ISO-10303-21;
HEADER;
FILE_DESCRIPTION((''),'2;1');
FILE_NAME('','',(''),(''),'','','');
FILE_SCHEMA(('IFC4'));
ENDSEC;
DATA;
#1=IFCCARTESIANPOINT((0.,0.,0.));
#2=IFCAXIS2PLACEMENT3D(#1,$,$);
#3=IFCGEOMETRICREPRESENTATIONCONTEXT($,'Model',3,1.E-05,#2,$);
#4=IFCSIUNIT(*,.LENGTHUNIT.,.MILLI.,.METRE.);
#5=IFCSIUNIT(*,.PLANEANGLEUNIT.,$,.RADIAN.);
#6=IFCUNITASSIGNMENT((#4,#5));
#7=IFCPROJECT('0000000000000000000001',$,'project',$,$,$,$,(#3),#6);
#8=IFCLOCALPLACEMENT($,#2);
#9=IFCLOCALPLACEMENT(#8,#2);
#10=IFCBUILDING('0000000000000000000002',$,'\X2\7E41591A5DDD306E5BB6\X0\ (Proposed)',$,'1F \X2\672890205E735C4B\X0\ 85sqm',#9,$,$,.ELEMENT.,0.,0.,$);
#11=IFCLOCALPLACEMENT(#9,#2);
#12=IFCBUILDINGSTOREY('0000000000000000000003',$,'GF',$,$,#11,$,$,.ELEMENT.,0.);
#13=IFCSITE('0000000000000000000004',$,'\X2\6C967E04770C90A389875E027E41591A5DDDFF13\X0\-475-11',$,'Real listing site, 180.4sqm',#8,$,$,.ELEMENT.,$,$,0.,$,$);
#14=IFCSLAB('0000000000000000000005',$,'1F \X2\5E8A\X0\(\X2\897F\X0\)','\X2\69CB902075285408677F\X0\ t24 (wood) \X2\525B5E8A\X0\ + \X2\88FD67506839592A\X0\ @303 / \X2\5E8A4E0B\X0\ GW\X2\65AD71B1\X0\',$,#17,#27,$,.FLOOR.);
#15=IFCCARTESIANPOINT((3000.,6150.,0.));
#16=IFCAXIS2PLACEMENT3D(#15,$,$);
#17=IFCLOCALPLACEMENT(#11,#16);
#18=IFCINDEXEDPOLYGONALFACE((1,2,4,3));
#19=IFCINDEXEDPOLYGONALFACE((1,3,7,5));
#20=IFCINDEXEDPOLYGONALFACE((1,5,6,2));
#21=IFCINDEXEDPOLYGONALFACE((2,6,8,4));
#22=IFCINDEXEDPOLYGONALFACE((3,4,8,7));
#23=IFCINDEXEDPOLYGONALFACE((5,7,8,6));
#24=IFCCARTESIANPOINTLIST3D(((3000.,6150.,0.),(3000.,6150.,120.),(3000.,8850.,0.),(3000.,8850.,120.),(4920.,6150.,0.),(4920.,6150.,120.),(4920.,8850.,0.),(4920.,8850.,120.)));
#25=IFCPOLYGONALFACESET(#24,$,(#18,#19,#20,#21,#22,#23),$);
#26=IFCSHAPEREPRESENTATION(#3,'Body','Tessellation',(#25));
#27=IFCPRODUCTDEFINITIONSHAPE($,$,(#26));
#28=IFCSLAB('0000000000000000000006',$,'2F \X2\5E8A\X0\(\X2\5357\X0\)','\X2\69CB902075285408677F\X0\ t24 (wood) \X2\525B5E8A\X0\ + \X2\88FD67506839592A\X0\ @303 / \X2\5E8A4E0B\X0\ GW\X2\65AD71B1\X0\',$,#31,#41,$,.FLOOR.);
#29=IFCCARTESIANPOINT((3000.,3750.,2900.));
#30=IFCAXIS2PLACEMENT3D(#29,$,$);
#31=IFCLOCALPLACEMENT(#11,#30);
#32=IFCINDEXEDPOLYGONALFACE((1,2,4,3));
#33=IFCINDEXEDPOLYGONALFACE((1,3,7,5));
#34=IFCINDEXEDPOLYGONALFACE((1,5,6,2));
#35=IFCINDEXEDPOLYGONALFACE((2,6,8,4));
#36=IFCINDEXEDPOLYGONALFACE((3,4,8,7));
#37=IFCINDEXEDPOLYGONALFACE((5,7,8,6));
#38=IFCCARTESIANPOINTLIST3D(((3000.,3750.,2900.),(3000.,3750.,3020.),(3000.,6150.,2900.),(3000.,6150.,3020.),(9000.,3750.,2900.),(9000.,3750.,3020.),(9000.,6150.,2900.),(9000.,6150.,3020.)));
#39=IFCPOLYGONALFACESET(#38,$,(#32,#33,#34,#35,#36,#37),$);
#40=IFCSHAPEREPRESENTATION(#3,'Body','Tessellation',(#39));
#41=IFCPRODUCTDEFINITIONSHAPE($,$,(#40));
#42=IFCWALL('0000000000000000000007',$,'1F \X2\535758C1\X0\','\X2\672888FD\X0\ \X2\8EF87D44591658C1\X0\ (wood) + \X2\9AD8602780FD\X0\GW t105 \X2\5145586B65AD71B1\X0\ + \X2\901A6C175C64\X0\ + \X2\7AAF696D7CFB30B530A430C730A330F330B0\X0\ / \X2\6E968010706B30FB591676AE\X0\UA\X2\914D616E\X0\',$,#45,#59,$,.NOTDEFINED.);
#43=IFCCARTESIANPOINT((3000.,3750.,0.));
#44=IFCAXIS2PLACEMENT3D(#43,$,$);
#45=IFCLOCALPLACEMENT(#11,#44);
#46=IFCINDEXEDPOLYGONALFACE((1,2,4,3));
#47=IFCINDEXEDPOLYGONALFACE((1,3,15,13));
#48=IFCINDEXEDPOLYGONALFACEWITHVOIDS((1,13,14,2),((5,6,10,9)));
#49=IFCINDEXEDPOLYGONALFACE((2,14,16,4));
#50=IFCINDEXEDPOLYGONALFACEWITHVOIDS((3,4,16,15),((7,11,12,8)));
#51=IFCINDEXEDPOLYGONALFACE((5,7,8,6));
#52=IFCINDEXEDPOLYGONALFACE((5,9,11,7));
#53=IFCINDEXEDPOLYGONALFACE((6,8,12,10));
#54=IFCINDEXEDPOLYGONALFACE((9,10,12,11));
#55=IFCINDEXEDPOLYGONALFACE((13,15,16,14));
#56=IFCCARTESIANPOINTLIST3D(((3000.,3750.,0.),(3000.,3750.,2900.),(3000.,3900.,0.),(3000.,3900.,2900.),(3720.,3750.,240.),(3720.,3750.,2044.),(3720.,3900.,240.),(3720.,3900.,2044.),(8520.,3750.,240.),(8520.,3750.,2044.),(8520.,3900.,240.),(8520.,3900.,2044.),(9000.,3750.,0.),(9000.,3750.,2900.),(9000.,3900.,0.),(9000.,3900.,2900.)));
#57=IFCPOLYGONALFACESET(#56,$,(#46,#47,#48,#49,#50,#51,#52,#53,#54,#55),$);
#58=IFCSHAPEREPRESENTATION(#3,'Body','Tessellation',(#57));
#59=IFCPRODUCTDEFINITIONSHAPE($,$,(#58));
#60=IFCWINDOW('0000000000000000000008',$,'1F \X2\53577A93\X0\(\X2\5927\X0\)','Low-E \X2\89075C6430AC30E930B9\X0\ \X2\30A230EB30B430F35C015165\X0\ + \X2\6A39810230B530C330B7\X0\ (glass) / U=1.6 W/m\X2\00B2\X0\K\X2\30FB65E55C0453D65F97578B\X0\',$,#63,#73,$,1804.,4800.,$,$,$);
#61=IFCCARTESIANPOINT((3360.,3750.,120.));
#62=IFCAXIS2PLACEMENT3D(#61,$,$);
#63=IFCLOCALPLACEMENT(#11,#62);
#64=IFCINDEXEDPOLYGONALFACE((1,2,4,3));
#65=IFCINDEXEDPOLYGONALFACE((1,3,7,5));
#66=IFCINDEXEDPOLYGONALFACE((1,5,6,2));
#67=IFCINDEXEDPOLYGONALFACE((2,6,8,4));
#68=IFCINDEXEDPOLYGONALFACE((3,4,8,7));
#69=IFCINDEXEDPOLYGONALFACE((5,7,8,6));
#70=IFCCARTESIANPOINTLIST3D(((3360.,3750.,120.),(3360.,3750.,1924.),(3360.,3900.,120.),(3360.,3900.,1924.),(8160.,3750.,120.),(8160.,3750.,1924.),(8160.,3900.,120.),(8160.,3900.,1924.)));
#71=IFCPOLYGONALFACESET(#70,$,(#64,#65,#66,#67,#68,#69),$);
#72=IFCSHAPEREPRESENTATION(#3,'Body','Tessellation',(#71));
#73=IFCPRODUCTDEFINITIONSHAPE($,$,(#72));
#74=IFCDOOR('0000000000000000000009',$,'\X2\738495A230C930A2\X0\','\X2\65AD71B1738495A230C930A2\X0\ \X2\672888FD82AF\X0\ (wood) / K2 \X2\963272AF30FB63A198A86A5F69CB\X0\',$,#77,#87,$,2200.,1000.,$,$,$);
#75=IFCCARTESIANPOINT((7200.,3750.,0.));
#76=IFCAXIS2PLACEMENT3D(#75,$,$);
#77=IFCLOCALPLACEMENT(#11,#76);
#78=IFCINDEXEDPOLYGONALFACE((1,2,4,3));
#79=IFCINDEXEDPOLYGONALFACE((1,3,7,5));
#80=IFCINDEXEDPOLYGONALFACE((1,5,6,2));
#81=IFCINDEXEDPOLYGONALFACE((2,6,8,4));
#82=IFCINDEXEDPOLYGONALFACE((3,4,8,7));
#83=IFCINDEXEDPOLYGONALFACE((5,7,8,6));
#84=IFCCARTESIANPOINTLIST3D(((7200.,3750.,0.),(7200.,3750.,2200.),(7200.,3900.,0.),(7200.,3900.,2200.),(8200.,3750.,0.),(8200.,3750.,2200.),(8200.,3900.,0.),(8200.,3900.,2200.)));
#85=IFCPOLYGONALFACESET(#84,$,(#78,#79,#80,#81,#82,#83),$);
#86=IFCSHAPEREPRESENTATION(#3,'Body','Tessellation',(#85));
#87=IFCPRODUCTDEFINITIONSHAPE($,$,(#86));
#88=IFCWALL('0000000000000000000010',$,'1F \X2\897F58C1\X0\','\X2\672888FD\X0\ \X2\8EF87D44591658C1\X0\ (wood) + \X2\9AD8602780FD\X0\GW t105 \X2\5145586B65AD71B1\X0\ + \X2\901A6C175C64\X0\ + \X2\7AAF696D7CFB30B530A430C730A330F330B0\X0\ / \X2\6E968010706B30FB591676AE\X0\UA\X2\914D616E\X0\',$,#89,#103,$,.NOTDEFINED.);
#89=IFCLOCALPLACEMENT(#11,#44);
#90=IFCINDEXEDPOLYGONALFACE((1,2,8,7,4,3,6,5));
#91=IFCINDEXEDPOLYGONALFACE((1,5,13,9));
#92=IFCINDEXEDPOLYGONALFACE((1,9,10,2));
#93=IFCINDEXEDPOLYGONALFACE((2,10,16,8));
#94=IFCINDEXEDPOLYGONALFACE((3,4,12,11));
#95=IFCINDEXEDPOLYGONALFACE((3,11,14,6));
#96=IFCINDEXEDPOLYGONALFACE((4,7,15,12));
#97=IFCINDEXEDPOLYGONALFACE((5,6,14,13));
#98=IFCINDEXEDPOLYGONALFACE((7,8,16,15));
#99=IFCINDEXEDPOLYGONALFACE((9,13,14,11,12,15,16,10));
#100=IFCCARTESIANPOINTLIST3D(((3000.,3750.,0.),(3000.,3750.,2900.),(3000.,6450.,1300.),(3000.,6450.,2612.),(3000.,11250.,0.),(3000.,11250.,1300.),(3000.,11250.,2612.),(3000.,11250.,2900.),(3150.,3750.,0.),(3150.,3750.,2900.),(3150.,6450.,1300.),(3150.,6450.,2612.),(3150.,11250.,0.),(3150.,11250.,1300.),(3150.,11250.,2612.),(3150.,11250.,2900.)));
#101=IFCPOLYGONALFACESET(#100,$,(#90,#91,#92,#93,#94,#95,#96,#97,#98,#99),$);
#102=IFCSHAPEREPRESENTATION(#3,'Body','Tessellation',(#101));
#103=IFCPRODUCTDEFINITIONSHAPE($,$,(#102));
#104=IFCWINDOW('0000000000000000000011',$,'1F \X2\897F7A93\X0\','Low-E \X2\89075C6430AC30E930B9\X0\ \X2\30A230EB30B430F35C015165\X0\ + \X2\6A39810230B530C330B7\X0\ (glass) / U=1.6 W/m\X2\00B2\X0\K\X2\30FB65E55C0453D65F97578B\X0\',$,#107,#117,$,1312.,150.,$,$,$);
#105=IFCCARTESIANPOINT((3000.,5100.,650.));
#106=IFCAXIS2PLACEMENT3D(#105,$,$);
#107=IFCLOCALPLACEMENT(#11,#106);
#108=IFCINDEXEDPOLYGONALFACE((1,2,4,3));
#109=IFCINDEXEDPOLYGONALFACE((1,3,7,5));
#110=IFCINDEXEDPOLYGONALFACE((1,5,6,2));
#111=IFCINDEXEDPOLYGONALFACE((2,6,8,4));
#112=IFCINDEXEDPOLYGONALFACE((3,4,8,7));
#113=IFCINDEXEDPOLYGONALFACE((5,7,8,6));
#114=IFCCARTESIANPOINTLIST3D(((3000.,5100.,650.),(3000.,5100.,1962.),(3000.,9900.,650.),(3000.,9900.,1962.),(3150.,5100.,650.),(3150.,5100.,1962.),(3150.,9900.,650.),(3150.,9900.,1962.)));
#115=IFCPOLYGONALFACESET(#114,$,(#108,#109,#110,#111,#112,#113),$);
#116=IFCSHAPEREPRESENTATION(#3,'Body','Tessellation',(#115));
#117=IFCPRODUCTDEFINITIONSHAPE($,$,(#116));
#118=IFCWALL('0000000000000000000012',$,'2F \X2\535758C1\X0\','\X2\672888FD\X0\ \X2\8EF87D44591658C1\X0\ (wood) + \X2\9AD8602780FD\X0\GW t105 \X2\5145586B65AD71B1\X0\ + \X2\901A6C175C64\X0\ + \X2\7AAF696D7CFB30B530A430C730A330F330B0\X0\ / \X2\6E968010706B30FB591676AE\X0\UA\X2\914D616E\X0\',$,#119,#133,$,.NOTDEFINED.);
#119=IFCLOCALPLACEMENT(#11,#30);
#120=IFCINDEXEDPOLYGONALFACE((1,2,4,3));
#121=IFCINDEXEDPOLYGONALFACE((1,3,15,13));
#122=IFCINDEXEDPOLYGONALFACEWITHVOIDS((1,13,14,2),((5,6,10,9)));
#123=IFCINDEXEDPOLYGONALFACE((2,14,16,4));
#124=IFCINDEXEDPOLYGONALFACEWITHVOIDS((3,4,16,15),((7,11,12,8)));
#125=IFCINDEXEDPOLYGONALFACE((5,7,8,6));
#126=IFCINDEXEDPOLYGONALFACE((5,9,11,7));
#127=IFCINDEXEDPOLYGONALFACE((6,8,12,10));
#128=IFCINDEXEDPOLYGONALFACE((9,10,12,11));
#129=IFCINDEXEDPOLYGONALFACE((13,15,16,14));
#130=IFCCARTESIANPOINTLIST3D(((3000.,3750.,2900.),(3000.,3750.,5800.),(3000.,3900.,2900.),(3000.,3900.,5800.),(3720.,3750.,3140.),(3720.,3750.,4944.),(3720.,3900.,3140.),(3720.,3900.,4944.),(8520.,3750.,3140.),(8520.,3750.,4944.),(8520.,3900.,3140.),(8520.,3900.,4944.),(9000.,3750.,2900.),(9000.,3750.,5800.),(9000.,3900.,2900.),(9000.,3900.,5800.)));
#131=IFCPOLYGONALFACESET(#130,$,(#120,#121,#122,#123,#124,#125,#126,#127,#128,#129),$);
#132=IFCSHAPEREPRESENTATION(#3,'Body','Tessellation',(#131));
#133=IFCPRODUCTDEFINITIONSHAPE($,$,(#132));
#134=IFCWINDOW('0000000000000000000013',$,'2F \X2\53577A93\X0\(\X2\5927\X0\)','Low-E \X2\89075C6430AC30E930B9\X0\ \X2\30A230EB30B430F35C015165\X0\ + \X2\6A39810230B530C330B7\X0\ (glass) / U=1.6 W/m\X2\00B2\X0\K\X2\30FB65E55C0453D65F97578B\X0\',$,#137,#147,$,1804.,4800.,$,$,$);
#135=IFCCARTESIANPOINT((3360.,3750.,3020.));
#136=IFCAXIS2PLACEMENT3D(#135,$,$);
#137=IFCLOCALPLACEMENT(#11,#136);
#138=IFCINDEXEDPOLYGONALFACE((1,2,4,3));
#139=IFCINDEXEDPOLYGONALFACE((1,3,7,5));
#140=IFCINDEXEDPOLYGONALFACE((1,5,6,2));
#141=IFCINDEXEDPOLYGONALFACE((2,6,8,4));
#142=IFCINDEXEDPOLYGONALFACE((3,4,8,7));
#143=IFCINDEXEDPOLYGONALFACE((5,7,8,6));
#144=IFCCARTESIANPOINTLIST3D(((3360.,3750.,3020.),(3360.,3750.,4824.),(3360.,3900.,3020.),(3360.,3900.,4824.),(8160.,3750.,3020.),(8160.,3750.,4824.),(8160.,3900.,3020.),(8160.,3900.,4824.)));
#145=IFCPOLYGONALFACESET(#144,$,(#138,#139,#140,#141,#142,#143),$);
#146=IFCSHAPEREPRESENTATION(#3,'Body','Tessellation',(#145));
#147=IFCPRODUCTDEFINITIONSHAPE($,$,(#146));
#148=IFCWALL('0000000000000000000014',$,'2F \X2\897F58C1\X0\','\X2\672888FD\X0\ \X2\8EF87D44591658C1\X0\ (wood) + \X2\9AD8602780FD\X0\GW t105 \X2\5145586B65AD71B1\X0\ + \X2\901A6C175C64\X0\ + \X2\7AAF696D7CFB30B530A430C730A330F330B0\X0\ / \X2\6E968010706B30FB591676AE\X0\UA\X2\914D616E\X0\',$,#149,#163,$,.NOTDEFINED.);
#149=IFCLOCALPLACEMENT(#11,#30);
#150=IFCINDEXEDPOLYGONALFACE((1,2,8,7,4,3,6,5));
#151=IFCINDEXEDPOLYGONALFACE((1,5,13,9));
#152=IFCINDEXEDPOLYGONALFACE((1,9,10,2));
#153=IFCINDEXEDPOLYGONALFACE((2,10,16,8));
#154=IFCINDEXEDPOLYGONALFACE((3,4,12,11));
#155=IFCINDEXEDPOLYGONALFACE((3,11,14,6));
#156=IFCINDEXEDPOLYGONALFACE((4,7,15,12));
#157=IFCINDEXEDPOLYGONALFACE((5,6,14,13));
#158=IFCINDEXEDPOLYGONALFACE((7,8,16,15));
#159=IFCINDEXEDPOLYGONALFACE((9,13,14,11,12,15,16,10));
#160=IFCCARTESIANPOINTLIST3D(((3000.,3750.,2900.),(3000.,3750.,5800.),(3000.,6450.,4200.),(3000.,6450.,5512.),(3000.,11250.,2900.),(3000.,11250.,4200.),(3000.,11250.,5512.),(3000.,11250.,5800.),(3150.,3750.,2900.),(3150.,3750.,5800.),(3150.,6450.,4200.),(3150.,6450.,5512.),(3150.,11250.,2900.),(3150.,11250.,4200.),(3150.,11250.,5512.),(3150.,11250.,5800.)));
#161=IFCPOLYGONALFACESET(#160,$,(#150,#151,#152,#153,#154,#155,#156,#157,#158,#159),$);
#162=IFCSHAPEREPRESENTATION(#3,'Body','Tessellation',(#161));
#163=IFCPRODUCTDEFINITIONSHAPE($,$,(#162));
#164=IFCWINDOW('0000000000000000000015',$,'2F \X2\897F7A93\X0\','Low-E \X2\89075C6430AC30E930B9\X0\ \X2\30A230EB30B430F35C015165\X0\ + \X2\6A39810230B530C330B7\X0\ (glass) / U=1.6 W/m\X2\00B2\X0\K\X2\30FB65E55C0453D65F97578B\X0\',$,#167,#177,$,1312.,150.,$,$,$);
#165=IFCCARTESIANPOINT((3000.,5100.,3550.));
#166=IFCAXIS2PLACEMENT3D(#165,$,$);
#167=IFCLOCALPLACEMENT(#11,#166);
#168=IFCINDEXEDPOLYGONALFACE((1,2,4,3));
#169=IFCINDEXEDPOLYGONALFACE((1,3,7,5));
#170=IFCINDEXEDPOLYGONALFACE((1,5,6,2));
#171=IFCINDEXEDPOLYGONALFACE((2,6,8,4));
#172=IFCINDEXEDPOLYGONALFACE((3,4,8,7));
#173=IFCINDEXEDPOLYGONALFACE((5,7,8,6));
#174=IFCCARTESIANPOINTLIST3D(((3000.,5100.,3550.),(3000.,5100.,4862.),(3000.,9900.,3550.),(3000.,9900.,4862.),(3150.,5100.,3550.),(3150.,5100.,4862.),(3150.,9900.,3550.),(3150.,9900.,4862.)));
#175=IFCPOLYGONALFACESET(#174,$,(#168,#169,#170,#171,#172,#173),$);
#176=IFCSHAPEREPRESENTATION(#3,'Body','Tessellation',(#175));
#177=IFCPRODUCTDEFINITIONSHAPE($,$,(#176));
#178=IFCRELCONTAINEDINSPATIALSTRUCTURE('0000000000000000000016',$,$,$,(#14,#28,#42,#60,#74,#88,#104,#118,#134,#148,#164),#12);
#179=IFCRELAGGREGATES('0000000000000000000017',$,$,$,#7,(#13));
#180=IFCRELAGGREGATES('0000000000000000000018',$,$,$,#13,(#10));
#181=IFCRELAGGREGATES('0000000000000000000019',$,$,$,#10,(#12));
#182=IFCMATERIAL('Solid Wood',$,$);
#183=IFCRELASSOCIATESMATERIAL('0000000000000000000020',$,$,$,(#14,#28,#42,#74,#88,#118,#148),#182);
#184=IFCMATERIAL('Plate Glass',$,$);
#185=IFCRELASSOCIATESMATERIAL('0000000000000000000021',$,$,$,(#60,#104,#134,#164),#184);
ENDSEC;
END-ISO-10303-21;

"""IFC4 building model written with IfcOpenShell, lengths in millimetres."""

from ifc_helpers import new_model, si_unit, frame, frame_2d, origin, place, context, project, spatial, rectangle, extrude, material, element, fill, save


model = new_model("IFC4")

# Units and contexts
model_context = context("Model", 3, precision=1e-05, world=origin())
ifc_project = project(units=[si_unit("LENGTHUNIT", "METRE", prefix="MILLI"), si_unit("PLANEANGLEUNIT", "RADIAN")], contexts=[model_context])

# Site, building, storey
site_placement = place(None, origin())
site = spatial("IfcSite", under=ifc_project, at=site_placement, Name="沖縄県那覇市繁多川３-475-11", ObjectType="Real listing site, 180.4sqm", CompositionType="ELEMENT", RefElevation=0.0)
building_placement = place(site_placement, origin())
building = spatial("IfcBuilding", under=site, at=building_placement, Name="繁多川の家 (Proposed)", ObjectType="1F 木造平屋 85sqm", CompositionType="ELEMENT", ElevationOfRefHeight=0.0, ElevationOfTerrain=0.0)
storey_placement = place(building_placement, origin())
storey = spatial("IfcBuildingStorey", under=building, at=storey_placement, Name="GF", CompositionType="ELEMENT", Elevation=0.0)

# Slabs
ifc_material_1 = material(Name="Solid Wood")
slab_1_placement = place(storey_placement, frame((3000.0, 6150.0, 0.0)))
element("IfcSlab", 1, at=slab_1_placement, inside=storey, material=ifc_material_1, Name="1F 床(西)", Description="構造用合板 t24 (wood) 剛床 + 製材根太 @303 / 床下 GW断熱", PredefinedType="FLOOR", context=model_context, shape_type="SweptSolid", body=[
    extrude(rectangle(XDim=1920.0, YDim=2700.0, at=frame_2d((960.0, 1350.0))), frame((3000.0, 6150.0, 0.0)), (0.0, 0.0, 1.0), 120.0),
])
slab_2_placement = place(storey_placement, frame((3000.0, 3750.0, 2900.0)))
element("IfcSlab", 2, at=slab_2_placement, inside=storey, material=ifc_material_1, Name="2F 床(南)", Description="構造用合板 t24 (wood) 剛床 + 製材根太 @303 / 床下 GW断熱", PredefinedType="FLOOR", context=model_context, shape_type="SweptSolid", body=[
    extrude(rectangle(XDim=6000.0, YDim=2400.0, at=frame_2d((3000.0, 1200.0))), frame((3000.0, 3750.0, 2900.0)), (0.0, 0.0, 1.0), 120.0),
])

# Wall, openings, window, door
wall_1_placement = place(storey_placement, frame((3000.0, 3750.0, 0.0)))
wall_1 = element("IfcWall", 3, at=wall_1_placement, inside=storey, material=ifc_material_1, Name="1F 南壁", Description="木製 軸組外壁 (wood) + 高性能GW t105 充填断熱 + 通気層 + 窯業系サイディング / 準耐火・外皮UA配慮", PredefinedType="NOTDEFINED", context=model_context, shape_type="SweptSolid", body=[
    extrude(rectangle(XDim=6000.0, YDim=150.0, at=frame_2d((3000.0, 75.0))), frame((3000.0, 3750.0, 0.0)), (0.0, 0.0, 1.0), 2900.0),
])
opening_1_placement = place(storey_placement, frame((3360.0, 3750.0, 120.0)))
opening_1 = element("IfcOpeningElement", 4, at=opening_1_placement, cuts=wall_1, PredefinedType="NOTDEFINED", context=model_context, shape_type="SweptSolid", body=[
    extrude(rectangle(XDim=4800.0, YDim=150.0, at=frame_2d((2400.0, 75.0))), frame((3360.0, 3750.0, 120.0)), (0.0, 0.0, 1.0), 1804.0),
])
opening_2_placement = place(storey_placement, frame((7200.0, 3750.0, 0.0)))
opening_2 = element("IfcOpeningElement", 5, at=opening_2_placement, cuts=wall_1, PredefinedType="NOTDEFINED", context=model_context, shape_type="SweptSolid", body=[
    extrude(rectangle(XDim=1000.0, YDim=150.0, at=frame_2d((500.0, 75.0))), frame((7200.0, 3750.0, 0.0)), (0.0, 0.0, 1.0), 2200.0),
])
ifc_material_2 = material(Name="Plate Glass")
window_1_placement = place(storey_placement, frame((3360.0, 3750.0, 120.0)))
window_1 = element("IfcWindow", 6, at=window_1_placement, inside=storey, material=ifc_material_2, Name="1F 南窓(大)", Description="Low-E 複層ガラス アルゴン封入 + 樹脂サッシ (glass) / U=1.6 W/m²K・日射取得型", OverallHeight=1804.0, OverallWidth=4800.0, context=model_context, shape_type="SweptSolid", body=[
    extrude(rectangle(XDim=4800.0, YDim=150.0, at=frame_2d((2400.0, 75.0))), frame((3360.0, 3750.0, 120.0)), (0.0, 0.0, 1.0), 1804.0),
])
fill(opening_1, window_1)
door_placement = place(storey_placement, frame((7200.0, 3750.0, 0.0)))
door = element("IfcDoor", 7, at=door_placement, inside=storey, material=ifc_material_1, Name="玄関ドア", Description="断熱玄関ドア 木製芯 (wood) / K2 防犯・採風機構", OverallHeight=2200.0, OverallWidth=1000.0, context=model_context, shape_type="SweptSolid", body=[
    extrude(rectangle(XDim=1000.0, YDim=150.0, at=frame_2d((500.0, 75.0))), frame((7200.0, 3750.0, 0.0)), (0.0, 0.0, 1.0), 2200.0),
])
fill(opening_2, door)

# Walls, openings, windows
wall_2_placement = place(storey_placement, frame((3000.0, 3750.0, 0.0)))
wall_2 = element("IfcWall", 8, at=wall_2_placement, inside=storey, material=ifc_material_1, Name="1F 西壁", Description="木製 軸組外壁 (wood) + 高性能GW t105 充填断熱 + 通気層 + 窯業系サイディング / 準耐火・外皮UA配慮", PredefinedType="NOTDEFINED", context=model_context, shape_type="SweptSolid", body=[
    extrude(rectangle(XDim=150.0, YDim=7500.0, at=frame_2d((75.0, 3750.0))), frame((3000.0, 3750.0, 0.0)), (0.0, 0.0, 1.0), 2900.0),
])
opening_3_placement = place(storey_placement, frame((3000.0, 5100.0, 650.0)))
opening_3 = element("IfcOpeningElement", 9, at=opening_3_placement, cuts=wall_2, PredefinedType="NOTDEFINED", context=model_context, shape_type="SweptSolid", body=[
    extrude(rectangle(XDim=150.0, YDim=4800.0, at=frame_2d((75.0, 2400.0))), frame((3000.0, 5100.0, 650.0)), (0.0, 0.0, 1.0), 1312.0),
])
window_2_placement = place(storey_placement, frame((3000.0, 5100.0, 650.0)))
window_2 = element("IfcWindow", 10, at=window_2_placement, inside=storey, material=ifc_material_2, Name="1F 西窓", Description="Low-E 複層ガラス アルゴン封入 + 樹脂サッシ (glass) / U=1.6 W/m²K・日射取得型", OverallHeight=1312.0, OverallWidth=150.0, context=model_context, shape_type="SweptSolid", body=[
    extrude(rectangle(XDim=150.0, YDim=4800.0, at=frame_2d((75.0, 2400.0))), frame((3000.0, 5100.0, 650.0)), (0.0, 0.0, 1.0), 1312.0),
])
fill(opening_3, window_2)
wall_3_placement = place(storey_placement, frame((3000.0, 3750.0, 2900.0)))
wall_3 = element("IfcWall", 11, at=wall_3_placement, inside=storey, material=ifc_material_1, Name="2F 南壁", Description="木製 軸組外壁 (wood) + 高性能GW t105 充填断熱 + 通気層 + 窯業系サイディング / 準耐火・外皮UA配慮", PredefinedType="NOTDEFINED", context=model_context, shape_type="SweptSolid", body=[
    extrude(rectangle(XDim=6000.0, YDim=150.0, at=frame_2d((3000.0, 75.0))), frame((3000.0, 3750.0, 2900.0)), (0.0, 0.0, 1.0), 2900.0),
])
opening_4_placement = place(storey_placement, frame((3360.0, 3750.0, 3020.0)))
opening_4 = element("IfcOpeningElement", 12, at=opening_4_placement, cuts=wall_3, PredefinedType="NOTDEFINED", context=model_context, shape_type="SweptSolid", body=[
    extrude(rectangle(XDim=4800.0, YDim=150.0, at=frame_2d((2400.0, 75.0))), frame((3360.0, 3750.0, 3020.0)), (0.0, 0.0, 1.0), 1804.0),
])
window_3_placement = place(storey_placement, frame((3360.0, 3750.0, 3020.0)))
window_3 = element("IfcWindow", 13, at=window_3_placement, inside=storey, material=ifc_material_2, Name="2F 南窓(大)", Description="Low-E 複層ガラス アルゴン封入 + 樹脂サッシ (glass) / U=1.6 W/m²K・日射取得型", OverallHeight=1804.0, OverallWidth=4800.0, context=model_context, shape_type="SweptSolid", body=[
    extrude(rectangle(XDim=4800.0, YDim=150.0, at=frame_2d((2400.0, 75.0))), frame((3360.0, 3750.0, 3020.0)), (0.0, 0.0, 1.0), 1804.0),
])
fill(opening_4, window_3)
wall_4_placement = place(storey_placement, frame((3000.0, 3750.0, 2900.0)))
wall_4 = element("IfcWall", 14, at=wall_4_placement, inside=storey, material=ifc_material_1, Name="2F 西壁", Description="木製 軸組外壁 (wood) + 高性能GW t105 充填断熱 + 通気層 + 窯業系サイディング / 準耐火・外皮UA配慮", PredefinedType="NOTDEFINED", context=model_context, shape_type="SweptSolid", body=[
    extrude(rectangle(XDim=150.0, YDim=7500.0, at=frame_2d((75.0, 3750.0))), frame((3000.0, 3750.0, 2900.0)), (0.0, 0.0, 1.0), 2900.0),
])
opening_5_placement = place(storey_placement, frame((3000.0, 5100.0, 3550.0)))
opening_5 = element("IfcOpeningElement", 15, at=opening_5_placement, cuts=wall_4, PredefinedType="NOTDEFINED", context=model_context, shape_type="SweptSolid", body=[
    extrude(rectangle(XDim=150.0, YDim=4800.0, at=frame_2d((75.0, 2400.0))), frame((3000.0, 5100.0, 3550.0)), (0.0, 0.0, 1.0), 1312.0),
])
window_4_placement = place(storey_placement, frame((3000.0, 5100.0, 3550.0)))
window_4 = element("IfcWindow", 16, at=window_4_placement, inside=storey, material=ifc_material_2, Name="2F 西窓", Description="Low-E 複層ガラス アルゴン封入 + 樹脂サッシ (glass) / U=1.6 W/m²K・日射取得型", OverallHeight=1312.0, OverallWidth=150.0, context=model_context, shape_type="SweptSolid", body=[
    extrude(rectangle(XDim=150.0, YDim=4800.0, at=frame_2d((75.0, 2400.0))), frame((3000.0, 5100.0, 3550.0)), (0.0, 0.0, 1.0), 1312.0),
])
fill(opening_5, window_4)

save(model, "model.ifc")
